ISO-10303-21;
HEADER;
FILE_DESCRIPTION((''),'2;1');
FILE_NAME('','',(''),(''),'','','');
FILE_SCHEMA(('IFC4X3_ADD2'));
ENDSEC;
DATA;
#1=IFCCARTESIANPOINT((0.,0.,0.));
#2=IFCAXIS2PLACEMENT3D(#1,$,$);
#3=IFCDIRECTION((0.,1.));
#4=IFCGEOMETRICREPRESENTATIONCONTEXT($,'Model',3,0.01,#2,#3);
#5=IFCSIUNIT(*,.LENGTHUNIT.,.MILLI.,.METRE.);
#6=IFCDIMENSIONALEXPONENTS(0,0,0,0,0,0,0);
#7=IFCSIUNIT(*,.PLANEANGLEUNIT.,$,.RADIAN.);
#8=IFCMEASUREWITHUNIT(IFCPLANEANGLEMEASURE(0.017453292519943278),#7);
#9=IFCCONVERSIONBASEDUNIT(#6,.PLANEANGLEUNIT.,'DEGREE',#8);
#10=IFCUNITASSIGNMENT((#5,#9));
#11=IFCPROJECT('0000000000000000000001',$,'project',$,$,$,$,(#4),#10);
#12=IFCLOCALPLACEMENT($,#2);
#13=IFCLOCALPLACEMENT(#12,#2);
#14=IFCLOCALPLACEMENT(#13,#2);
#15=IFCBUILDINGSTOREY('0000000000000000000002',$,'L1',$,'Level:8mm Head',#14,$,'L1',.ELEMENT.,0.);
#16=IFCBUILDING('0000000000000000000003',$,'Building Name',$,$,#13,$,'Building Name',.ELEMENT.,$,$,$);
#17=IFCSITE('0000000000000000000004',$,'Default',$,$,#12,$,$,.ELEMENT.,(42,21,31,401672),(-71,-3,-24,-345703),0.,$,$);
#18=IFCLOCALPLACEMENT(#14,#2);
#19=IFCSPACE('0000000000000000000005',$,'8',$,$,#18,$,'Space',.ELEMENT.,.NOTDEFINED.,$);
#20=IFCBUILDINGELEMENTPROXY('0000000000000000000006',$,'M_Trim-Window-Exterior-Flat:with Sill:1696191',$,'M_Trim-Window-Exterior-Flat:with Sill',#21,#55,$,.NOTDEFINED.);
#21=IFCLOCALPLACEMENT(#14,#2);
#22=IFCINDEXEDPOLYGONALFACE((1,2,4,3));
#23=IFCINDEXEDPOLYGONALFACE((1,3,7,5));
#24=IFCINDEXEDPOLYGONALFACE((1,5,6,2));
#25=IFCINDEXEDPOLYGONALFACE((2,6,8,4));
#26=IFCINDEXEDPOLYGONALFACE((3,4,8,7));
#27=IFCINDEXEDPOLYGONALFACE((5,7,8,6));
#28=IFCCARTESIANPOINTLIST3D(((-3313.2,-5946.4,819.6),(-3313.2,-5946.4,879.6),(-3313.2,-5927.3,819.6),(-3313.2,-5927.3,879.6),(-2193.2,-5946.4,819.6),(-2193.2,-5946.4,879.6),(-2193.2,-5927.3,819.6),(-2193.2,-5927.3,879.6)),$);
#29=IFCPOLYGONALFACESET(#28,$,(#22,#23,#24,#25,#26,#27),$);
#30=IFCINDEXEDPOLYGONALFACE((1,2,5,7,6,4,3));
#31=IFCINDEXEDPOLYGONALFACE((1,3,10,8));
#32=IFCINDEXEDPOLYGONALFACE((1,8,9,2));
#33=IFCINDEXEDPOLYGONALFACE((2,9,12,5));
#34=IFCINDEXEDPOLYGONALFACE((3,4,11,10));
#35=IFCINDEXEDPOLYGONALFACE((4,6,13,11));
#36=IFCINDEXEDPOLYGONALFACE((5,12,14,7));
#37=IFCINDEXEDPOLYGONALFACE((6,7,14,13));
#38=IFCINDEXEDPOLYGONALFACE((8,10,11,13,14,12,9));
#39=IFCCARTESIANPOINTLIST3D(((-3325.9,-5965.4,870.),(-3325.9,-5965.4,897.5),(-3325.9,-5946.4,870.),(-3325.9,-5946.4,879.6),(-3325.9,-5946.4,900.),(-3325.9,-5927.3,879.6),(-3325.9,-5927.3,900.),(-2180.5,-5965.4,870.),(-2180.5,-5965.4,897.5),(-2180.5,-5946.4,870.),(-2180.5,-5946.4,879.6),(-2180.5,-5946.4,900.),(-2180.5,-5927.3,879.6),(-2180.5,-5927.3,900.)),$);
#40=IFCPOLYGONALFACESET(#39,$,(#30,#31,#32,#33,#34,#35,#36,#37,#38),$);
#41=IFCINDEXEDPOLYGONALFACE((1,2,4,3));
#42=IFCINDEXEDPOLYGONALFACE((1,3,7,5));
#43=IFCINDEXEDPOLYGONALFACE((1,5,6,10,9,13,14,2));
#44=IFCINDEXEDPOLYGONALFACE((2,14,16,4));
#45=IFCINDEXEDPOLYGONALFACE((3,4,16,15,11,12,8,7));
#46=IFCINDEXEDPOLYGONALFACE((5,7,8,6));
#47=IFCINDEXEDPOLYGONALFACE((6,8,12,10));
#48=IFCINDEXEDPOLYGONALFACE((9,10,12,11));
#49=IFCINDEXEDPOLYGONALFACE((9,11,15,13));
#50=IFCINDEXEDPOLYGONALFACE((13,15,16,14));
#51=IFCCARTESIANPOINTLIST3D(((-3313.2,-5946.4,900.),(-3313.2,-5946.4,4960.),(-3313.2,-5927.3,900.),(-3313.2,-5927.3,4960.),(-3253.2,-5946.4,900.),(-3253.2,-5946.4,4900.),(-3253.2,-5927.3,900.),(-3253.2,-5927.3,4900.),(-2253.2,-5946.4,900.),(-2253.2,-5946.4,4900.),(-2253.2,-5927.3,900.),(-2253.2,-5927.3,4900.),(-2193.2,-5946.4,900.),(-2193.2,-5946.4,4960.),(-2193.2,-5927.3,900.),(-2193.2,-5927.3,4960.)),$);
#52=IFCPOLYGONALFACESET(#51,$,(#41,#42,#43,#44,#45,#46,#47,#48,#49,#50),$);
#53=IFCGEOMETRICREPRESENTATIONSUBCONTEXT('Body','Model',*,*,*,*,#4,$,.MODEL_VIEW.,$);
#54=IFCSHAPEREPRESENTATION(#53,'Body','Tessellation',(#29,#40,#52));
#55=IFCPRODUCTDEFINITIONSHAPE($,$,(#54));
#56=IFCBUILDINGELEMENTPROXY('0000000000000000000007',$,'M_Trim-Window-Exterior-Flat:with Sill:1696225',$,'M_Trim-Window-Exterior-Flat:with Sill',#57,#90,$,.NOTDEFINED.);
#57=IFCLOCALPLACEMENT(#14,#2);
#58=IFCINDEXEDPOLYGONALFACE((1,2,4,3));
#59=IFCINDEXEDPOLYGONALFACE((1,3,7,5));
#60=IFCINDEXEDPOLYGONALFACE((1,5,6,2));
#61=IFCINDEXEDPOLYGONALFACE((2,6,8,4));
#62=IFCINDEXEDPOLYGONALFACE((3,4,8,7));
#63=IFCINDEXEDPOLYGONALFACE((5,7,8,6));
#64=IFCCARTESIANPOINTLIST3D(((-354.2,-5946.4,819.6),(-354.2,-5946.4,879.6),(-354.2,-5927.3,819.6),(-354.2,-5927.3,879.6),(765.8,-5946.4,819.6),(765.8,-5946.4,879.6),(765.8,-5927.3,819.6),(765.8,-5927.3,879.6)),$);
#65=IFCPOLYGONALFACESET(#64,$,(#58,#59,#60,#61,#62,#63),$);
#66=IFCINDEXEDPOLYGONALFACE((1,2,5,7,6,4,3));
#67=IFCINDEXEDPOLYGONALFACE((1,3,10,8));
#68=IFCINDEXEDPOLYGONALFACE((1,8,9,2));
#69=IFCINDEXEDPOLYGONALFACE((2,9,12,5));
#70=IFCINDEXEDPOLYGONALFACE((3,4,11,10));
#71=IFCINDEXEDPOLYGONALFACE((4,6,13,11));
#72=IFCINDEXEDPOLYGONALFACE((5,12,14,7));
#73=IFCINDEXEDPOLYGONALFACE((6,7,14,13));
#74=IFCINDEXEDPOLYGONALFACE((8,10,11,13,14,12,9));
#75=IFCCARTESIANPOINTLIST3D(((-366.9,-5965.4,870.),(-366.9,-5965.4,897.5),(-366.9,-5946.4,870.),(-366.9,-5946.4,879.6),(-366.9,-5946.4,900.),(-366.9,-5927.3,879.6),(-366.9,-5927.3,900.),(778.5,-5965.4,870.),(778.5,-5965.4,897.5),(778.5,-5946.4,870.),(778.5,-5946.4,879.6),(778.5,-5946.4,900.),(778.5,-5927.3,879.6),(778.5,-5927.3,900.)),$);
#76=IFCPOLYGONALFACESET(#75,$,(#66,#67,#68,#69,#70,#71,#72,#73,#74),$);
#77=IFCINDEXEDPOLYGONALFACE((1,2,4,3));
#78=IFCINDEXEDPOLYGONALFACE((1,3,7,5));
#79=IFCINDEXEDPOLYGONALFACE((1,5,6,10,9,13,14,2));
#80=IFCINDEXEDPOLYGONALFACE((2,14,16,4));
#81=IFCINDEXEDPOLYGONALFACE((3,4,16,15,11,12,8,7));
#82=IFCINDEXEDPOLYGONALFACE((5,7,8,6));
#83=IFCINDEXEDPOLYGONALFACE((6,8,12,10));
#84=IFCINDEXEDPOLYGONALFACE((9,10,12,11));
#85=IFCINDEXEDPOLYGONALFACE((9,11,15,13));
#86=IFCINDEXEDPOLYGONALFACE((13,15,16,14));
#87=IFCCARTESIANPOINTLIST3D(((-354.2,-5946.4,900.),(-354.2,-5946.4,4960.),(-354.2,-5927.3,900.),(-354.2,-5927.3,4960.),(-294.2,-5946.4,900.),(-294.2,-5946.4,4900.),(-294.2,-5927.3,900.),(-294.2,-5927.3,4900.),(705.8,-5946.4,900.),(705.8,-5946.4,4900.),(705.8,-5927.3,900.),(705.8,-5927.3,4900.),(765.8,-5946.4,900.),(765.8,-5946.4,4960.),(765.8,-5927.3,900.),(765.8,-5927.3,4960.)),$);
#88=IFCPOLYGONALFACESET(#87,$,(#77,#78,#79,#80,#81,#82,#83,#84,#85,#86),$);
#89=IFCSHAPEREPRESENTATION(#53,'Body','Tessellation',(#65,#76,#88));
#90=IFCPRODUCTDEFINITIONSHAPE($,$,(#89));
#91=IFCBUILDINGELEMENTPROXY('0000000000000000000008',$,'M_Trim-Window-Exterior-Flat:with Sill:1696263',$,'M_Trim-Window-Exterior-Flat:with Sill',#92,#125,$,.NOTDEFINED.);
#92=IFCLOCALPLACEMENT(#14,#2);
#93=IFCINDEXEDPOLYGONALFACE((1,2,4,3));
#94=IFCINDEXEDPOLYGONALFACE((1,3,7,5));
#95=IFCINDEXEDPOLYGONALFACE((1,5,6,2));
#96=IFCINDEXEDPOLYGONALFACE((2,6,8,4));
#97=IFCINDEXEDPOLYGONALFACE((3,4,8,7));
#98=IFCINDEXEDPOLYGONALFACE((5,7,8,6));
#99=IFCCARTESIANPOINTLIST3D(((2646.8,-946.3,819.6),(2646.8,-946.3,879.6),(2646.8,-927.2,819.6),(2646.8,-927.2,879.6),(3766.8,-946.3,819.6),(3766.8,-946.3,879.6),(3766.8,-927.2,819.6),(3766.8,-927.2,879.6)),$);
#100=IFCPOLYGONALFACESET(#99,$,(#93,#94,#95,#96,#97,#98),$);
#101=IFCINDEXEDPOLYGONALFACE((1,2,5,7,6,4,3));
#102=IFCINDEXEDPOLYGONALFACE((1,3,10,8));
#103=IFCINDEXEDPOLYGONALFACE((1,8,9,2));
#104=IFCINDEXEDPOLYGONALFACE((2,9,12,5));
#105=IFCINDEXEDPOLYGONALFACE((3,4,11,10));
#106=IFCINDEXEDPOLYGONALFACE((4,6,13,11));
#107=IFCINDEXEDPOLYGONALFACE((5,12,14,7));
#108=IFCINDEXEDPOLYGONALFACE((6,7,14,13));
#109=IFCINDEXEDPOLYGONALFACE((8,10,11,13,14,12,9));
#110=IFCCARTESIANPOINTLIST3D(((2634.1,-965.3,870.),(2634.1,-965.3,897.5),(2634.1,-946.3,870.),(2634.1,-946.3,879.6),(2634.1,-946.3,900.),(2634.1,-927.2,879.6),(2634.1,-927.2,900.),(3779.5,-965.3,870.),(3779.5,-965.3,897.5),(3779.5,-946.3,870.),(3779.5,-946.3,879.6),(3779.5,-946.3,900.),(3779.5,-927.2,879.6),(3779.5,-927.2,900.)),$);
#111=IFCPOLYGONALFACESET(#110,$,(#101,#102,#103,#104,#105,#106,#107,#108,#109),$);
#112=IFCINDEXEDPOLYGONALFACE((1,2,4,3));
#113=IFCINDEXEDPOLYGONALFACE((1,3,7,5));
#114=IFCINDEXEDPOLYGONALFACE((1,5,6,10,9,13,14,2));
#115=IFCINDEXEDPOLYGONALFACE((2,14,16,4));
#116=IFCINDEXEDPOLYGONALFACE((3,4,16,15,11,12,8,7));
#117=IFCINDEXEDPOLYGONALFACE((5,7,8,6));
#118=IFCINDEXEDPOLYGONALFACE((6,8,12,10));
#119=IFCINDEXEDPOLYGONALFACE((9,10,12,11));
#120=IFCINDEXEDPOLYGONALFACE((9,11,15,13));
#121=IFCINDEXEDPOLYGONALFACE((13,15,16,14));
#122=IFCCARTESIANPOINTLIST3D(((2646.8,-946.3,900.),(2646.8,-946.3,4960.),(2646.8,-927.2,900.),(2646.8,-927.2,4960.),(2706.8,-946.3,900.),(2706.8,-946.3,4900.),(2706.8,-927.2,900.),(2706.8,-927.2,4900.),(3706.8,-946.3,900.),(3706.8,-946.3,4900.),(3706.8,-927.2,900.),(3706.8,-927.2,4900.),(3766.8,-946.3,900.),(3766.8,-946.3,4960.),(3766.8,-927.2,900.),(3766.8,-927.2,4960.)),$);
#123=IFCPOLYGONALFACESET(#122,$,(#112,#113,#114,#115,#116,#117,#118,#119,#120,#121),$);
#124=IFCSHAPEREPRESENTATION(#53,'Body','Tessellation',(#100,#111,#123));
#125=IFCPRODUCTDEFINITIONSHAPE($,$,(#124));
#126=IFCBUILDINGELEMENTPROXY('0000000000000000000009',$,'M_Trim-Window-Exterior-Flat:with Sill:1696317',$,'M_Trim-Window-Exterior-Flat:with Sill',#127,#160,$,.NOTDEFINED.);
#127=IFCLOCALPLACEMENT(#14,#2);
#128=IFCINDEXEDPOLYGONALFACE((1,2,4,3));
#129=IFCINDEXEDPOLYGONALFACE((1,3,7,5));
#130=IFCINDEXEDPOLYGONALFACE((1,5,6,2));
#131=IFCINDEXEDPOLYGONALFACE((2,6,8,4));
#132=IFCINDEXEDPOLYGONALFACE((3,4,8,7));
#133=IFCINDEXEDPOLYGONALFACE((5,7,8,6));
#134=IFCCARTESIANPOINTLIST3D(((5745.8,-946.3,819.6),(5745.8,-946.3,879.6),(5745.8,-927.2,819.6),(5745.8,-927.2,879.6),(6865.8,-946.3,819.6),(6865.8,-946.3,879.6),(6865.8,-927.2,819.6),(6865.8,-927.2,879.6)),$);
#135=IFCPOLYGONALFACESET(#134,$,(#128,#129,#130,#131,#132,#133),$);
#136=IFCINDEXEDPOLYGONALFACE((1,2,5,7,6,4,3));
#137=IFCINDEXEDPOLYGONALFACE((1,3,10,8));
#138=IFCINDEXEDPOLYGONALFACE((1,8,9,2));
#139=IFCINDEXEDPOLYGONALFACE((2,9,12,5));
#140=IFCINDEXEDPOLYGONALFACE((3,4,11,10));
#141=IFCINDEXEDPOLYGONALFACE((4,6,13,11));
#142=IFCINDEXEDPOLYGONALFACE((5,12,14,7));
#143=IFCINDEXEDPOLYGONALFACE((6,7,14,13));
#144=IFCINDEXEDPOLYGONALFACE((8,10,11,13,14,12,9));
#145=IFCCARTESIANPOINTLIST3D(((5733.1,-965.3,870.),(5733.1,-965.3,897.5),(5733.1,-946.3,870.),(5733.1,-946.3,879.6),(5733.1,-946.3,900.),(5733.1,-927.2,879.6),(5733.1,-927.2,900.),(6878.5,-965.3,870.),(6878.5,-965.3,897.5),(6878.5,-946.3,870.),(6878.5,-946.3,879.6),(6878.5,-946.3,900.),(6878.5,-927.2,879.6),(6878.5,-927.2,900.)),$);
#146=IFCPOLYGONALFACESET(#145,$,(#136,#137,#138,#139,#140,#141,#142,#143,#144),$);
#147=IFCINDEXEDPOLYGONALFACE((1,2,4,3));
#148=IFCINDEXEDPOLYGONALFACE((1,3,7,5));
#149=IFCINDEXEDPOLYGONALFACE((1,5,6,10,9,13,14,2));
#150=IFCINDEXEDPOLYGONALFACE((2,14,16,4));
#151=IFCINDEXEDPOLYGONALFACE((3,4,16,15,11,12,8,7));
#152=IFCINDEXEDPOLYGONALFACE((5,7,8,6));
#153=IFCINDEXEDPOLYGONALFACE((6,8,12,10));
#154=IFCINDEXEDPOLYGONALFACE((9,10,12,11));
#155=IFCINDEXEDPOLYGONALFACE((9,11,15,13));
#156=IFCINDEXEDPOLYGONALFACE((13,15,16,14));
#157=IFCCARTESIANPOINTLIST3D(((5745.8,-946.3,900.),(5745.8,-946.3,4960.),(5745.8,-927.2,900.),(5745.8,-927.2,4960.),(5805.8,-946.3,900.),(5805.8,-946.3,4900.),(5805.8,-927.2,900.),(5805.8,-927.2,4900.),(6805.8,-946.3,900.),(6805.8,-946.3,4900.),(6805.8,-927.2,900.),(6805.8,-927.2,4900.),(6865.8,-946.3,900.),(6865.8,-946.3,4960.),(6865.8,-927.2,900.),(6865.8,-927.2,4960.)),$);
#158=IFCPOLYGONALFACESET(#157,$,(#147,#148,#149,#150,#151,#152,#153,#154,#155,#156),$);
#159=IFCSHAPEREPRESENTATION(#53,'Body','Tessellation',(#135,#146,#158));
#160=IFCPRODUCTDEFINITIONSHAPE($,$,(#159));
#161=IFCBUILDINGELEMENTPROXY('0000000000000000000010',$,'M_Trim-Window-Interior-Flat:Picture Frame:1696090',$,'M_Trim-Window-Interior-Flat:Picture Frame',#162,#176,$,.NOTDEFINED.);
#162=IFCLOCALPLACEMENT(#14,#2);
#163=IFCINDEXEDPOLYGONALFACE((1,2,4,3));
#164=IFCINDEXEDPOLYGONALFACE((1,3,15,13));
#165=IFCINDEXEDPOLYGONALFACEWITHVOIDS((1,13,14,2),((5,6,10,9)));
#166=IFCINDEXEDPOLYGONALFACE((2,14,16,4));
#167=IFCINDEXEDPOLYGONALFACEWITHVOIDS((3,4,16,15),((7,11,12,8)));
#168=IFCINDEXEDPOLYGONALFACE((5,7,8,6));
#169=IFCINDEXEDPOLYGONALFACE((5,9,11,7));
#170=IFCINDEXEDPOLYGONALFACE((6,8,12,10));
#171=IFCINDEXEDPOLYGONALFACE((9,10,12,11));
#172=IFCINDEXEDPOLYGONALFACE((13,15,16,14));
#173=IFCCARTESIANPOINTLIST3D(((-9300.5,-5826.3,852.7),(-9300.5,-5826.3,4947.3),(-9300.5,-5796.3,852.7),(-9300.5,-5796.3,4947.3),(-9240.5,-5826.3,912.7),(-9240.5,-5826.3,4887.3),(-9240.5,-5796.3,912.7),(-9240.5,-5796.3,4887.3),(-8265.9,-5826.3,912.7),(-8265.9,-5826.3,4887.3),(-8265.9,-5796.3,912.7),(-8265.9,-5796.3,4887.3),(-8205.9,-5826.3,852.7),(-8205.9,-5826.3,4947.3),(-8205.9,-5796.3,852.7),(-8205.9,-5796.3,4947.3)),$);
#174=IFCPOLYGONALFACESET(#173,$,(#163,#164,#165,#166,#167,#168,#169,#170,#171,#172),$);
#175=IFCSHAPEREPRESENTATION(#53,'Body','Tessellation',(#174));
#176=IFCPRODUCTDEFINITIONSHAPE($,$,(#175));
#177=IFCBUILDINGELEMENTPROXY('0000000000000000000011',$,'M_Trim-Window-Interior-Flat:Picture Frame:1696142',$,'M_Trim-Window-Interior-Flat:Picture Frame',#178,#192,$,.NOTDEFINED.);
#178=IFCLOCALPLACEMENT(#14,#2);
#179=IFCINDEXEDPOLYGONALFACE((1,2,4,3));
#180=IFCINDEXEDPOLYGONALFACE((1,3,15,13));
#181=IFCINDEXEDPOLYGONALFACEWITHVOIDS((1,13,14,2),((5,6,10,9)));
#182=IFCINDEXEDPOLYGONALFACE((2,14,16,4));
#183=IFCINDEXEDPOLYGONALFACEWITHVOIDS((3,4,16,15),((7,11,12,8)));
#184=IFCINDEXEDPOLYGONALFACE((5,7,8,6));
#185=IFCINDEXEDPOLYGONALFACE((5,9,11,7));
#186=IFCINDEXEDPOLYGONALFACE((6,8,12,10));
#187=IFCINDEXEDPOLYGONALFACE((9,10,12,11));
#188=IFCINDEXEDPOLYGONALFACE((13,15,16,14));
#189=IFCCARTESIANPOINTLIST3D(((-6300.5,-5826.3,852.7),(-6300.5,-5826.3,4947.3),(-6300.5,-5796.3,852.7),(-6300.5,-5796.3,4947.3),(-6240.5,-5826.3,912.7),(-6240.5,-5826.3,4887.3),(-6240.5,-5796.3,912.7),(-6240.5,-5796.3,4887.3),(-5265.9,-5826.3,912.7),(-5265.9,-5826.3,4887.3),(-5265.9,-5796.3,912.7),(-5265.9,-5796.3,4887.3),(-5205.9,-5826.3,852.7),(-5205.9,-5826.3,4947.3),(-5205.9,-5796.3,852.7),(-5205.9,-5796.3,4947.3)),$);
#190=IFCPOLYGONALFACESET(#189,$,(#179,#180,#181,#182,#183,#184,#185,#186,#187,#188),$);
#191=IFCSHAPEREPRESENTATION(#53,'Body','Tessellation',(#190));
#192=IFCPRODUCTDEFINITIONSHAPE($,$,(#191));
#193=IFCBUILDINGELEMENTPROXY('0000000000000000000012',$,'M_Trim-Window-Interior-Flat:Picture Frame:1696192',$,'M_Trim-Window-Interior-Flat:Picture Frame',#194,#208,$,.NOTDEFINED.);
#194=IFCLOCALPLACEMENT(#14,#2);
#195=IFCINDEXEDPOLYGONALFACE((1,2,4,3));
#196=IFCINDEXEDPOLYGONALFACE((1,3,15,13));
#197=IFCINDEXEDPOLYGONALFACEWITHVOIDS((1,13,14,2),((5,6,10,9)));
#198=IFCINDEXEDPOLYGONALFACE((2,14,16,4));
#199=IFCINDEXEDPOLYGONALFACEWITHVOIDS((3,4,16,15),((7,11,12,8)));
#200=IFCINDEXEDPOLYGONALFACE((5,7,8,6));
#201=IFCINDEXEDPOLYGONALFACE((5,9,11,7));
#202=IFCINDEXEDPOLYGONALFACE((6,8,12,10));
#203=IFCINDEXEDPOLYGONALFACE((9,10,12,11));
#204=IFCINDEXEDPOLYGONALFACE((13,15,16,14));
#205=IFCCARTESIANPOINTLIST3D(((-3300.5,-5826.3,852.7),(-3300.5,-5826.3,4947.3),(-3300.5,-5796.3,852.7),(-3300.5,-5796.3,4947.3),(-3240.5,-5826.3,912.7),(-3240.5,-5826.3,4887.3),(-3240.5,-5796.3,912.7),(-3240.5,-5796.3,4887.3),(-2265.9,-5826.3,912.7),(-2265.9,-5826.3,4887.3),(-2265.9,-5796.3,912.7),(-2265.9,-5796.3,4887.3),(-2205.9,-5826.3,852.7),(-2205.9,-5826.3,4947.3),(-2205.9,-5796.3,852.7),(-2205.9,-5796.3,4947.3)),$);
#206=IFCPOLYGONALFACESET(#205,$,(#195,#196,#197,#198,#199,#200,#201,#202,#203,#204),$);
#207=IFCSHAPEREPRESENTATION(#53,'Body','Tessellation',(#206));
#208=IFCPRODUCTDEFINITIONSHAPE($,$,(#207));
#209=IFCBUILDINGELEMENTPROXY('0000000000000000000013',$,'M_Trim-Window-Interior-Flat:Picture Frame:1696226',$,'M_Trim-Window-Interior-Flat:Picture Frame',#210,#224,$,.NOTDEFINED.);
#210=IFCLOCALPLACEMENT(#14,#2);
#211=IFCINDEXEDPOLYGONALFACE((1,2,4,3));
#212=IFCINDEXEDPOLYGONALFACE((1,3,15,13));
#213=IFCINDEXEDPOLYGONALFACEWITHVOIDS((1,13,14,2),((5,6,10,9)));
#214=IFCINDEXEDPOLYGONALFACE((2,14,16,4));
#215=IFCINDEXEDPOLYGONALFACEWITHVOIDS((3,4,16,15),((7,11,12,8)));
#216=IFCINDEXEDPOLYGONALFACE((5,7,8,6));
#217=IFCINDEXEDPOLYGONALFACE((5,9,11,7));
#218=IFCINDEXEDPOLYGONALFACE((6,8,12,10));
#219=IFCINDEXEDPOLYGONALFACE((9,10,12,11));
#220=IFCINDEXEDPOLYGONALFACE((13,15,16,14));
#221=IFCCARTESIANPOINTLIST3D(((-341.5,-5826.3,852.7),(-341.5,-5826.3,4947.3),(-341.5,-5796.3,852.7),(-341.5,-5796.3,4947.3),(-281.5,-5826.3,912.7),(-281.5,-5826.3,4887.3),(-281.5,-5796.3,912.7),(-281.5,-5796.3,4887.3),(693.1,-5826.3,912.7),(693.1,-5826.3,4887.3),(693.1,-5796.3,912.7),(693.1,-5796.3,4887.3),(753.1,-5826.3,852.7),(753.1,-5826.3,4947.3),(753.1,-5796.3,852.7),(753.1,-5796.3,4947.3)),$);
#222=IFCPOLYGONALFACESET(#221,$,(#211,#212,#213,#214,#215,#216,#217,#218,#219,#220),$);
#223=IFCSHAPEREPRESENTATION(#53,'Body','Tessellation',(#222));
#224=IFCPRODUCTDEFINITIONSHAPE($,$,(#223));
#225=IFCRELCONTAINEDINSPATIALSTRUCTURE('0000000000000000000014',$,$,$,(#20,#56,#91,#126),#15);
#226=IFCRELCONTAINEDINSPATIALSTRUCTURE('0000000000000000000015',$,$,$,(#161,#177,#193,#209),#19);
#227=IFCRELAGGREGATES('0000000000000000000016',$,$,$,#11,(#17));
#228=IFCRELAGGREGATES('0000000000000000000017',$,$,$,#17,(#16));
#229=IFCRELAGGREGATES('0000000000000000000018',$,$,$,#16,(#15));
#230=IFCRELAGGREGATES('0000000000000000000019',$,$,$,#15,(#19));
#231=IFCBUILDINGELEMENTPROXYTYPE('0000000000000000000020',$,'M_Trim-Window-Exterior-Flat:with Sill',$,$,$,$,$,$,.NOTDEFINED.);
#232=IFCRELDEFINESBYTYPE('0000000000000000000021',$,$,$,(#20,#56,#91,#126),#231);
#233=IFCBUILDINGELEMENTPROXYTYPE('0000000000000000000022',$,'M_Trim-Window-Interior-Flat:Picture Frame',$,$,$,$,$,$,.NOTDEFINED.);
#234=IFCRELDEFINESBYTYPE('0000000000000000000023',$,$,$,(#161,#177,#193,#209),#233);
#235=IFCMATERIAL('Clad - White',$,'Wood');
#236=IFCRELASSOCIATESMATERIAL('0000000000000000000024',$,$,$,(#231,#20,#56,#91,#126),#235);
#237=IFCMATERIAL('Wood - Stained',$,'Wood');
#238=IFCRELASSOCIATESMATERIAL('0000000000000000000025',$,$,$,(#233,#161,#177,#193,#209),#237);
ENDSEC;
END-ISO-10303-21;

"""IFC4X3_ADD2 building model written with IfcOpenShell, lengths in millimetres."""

from ifc_helpers import new_model, entity, si_unit, converted_unit, direction, frame, frame_2d, origin, place, context, subcontext, project, spatial, polyline, rectangle, outline, extrude, source, transform, mapped, material, type_object, type_shapes, element, save


model = new_model("IFC4X3_ADD2")

# Units and contexts
model_context = context("Model", 3, precision=0.01, world=origin(), true_north=direction((0.0, 1.0)))
body_context = subcontext(model_context, "Body", "Model", "MODEL_VIEW")
ifc_project = project(units=[si_unit("LENGTHUNIT", "METRE", prefix="MILLI"), converted_unit("PLANEANGLEUNIT", "DEGREE", entity("IfcPlaneAngleMeasure", 0.017453292519943278), si_unit("PLANEANGLEUNIT", "RADIAN"), dimensions=[0, 0, 0, 0, 0, 0, 0])], contexts=[model_context])

# Site, building, storey
site_placement = place(None, origin())
site = spatial("IfcSite", under=ifc_project, at=site_placement, Name="Default", CompositionType="ELEMENT", RefLatitude=(42, 21, 31, 401672), RefLongitude=(-71, -3, -24, -345703), RefElevation=0.0)
building_placement = place(site_placement, origin())
building = spatial("IfcBuilding", under=site, at=building_placement, Name="Building Name", LongName="Building Name", CompositionType="ELEMENT")
storey_placement = place(building_placement, origin())
storey = spatial("IfcBuildingStorey", under=building, at=storey_placement, Name="L1", ObjectType="Level:8mm Head", LongName="L1", CompositionType="ELEMENT", Elevation=0.0)

# Building element proxies
ifc_material_1 = material(Name="Clad - White", Category="Wood")
ifc_material_2 = material(Name="Wood - Stained", Category="Wood")
building_element_proxy_type_1 = type_object("IfcBuildingElementProxyType", Name="M_Trim-Window-Exterior-Flat:with Sill", PredefinedType="NOTDEFINED", material=ifc_material_1)
shared_shape_1 = source(origin(), body_context, "Body", "SweptSolid", [
    extrude(rectangle(XDim=1120.0, YDim=60.0, at=frame_2d((0.0, 0.0), x_axis=(1.0, 0.0))), frame((0.0, -4050.4, 0.0), z_axis=(0.0, 0.0, 1.0), x_axis=(-1.0, 0.0, 0.0)), (0.0, 0.0, 1.0), 19.0),
    extrude(outline(polyline([(-19.0, -15.2), (0.0, -15.2), (0.0, -5.7), (19.0, -5.7), (19.0, 14.8), (0.0, 14.8), (-19.0, 12.3), (-19.0, -15.2)])), frame((-572.7, -4014.8, 19.0), z_axis=(1.0, 0.0, 0.0), x_axis=(0.0, 0.0, -1.0)), (0.0, 0.0, 1.0), 1145.4),
    extrude(outline(polyline([(-2045.0, -560.0), (2015.0, -560.0), (2015.0, -500.0), (-1985.0, -500.0), (-1985.0, 500.0), (2015.0, 500.0), (2015.0, 560.0), (-2045.0, 560.0), (-2045.0, -560.0)])), frame((0.0, -1985.0, 0.0), z_axis=(0.0, 0.0, 1.0), x_axis=(0.0, -1.0, 0.0)), (0.0, 0.0, 1.0), 19.0),
])
type_shapes(building_element_proxy_type_1, [shared_shape_1])
for number, where, z_axis, x_axis, name in (
    (1, (-2753.2, -5927.3, 4900.0), (0.0, -1.0, 0.0), (1.0, 0.0, 0.0), "M_Trim-Window-Exterior-Flat:with Sill:1696191"),
    (2, (205.8, -5927.3, 4900.0), (0.0, -1.0, 0.0), (1.0, 0.0, 0.0), "M_Trim-Window-Exterior-Flat:with Sill:1696225"),
    (3, (3206.8, -927.2, 4900.0), (0.0, -1.0, 0.0), (1.0, 0.0, 0.0), "M_Trim-Window-Exterior-Flat:with Sill:1696263"),
    (4, (6305.8, -927.2, 4900.0), (0.0, -1.0, 0.0), (1.0, 0.0, 0.0), "M_Trim-Window-Exterior-Flat:with Sill:1696317"),
):
    element("IfcBuildingElementProxy", number, at=place(storey_placement, frame(where, z_axis=z_axis, x_axis=x_axis)), inside=storey, type_object=building_element_proxy_type_1, material=ifc_material_1, Name=name, ObjectType="M_Trim-Window-Exterior-Flat:with Sill", PredefinedType="NOTDEFINED", context=body_context, shape_type="MappedRepresentation", body=[
        mapped(shared_shape_1, transform((0.0, 0.0, 0.0), scale=1.0)),
    ])

# Shared definitions
space_placement = place(storey_placement, origin())
space = spatial("IfcSpace", under=storey, at=space_placement, Name="8", LongName="Space", CompositionType="ELEMENT", PredefinedType="NOTDEFINED")

# Building element proxies
building_element_proxy_type_2 = type_object("IfcBuildingElementProxyType", Name="M_Trim-Window-Interior-Flat:Picture Frame", PredefinedType="NOTDEFINED", material=ifc_material_2)
shared_shape_2 = source(origin(), body_context, "Body", "SweptSolid", [
    extrude(outline(polyline([(-547.3, -2047.3), (547.3, -2047.3), (547.3, 2047.3), (-547.3, 2047.3), (-547.3, -2047.3)]), holes=[polyline([(-487.3, -1987.3), (-487.3, 1987.3), (487.3, 1987.3), (487.3, -1987.3), (-487.3, -1987.3)])]), frame((0.0, -2000.0, 0.0), z_axis=(0.0, 0.0, 1.0), x_axis=(-1.0, 0.0, 0.0)), (0.0, 0.0, 1.0), 30.0),
])
type_shapes(building_element_proxy_type_2, [shared_shape_2])
for number, where, z_axis, x_axis, name in (
    (5, (-8753.2, -5826.3, 4900.0), (0.0, 1.0, 0.0), (-1.0, 0.0, 0.0), "M_Trim-Window-Interior-Flat:Picture Frame:1696090"),
    (6, (-5753.2, -5826.3, 4900.0), (0.0, 1.0, 0.0), (-1.0, 0.0, 0.0), "M_Trim-Window-Interior-Flat:Picture Frame:1696142"),
    (7, (-2753.2, -5826.3, 4900.0), (0.0, 1.0, 0.0), (-1.0, 0.0, 0.0), "M_Trim-Window-Interior-Flat:Picture Frame:1696192"),
    (8, (205.8, -5826.3, 4900.0), (0.0, 1.0, 0.0), (-1.0, 0.0, 0.0), "M_Trim-Window-Interior-Flat:Picture Frame:1696226"),
):
    element("IfcBuildingElementProxy", number, at=place(space_placement, frame(where, z_axis=z_axis, x_axis=x_axis)), inside=space, type_object=building_element_proxy_type_2, material=ifc_material_2, Name=name, ObjectType="M_Trim-Window-Interior-Flat:Picture Frame", PredefinedType="NOTDEFINED", context=body_context, shape_type="MappedRepresentation", body=[
        mapped(shared_shape_2, transform((0.0, 0.0, 0.0), scale=1.0)),
    ])

save(model, "model.ifc")
